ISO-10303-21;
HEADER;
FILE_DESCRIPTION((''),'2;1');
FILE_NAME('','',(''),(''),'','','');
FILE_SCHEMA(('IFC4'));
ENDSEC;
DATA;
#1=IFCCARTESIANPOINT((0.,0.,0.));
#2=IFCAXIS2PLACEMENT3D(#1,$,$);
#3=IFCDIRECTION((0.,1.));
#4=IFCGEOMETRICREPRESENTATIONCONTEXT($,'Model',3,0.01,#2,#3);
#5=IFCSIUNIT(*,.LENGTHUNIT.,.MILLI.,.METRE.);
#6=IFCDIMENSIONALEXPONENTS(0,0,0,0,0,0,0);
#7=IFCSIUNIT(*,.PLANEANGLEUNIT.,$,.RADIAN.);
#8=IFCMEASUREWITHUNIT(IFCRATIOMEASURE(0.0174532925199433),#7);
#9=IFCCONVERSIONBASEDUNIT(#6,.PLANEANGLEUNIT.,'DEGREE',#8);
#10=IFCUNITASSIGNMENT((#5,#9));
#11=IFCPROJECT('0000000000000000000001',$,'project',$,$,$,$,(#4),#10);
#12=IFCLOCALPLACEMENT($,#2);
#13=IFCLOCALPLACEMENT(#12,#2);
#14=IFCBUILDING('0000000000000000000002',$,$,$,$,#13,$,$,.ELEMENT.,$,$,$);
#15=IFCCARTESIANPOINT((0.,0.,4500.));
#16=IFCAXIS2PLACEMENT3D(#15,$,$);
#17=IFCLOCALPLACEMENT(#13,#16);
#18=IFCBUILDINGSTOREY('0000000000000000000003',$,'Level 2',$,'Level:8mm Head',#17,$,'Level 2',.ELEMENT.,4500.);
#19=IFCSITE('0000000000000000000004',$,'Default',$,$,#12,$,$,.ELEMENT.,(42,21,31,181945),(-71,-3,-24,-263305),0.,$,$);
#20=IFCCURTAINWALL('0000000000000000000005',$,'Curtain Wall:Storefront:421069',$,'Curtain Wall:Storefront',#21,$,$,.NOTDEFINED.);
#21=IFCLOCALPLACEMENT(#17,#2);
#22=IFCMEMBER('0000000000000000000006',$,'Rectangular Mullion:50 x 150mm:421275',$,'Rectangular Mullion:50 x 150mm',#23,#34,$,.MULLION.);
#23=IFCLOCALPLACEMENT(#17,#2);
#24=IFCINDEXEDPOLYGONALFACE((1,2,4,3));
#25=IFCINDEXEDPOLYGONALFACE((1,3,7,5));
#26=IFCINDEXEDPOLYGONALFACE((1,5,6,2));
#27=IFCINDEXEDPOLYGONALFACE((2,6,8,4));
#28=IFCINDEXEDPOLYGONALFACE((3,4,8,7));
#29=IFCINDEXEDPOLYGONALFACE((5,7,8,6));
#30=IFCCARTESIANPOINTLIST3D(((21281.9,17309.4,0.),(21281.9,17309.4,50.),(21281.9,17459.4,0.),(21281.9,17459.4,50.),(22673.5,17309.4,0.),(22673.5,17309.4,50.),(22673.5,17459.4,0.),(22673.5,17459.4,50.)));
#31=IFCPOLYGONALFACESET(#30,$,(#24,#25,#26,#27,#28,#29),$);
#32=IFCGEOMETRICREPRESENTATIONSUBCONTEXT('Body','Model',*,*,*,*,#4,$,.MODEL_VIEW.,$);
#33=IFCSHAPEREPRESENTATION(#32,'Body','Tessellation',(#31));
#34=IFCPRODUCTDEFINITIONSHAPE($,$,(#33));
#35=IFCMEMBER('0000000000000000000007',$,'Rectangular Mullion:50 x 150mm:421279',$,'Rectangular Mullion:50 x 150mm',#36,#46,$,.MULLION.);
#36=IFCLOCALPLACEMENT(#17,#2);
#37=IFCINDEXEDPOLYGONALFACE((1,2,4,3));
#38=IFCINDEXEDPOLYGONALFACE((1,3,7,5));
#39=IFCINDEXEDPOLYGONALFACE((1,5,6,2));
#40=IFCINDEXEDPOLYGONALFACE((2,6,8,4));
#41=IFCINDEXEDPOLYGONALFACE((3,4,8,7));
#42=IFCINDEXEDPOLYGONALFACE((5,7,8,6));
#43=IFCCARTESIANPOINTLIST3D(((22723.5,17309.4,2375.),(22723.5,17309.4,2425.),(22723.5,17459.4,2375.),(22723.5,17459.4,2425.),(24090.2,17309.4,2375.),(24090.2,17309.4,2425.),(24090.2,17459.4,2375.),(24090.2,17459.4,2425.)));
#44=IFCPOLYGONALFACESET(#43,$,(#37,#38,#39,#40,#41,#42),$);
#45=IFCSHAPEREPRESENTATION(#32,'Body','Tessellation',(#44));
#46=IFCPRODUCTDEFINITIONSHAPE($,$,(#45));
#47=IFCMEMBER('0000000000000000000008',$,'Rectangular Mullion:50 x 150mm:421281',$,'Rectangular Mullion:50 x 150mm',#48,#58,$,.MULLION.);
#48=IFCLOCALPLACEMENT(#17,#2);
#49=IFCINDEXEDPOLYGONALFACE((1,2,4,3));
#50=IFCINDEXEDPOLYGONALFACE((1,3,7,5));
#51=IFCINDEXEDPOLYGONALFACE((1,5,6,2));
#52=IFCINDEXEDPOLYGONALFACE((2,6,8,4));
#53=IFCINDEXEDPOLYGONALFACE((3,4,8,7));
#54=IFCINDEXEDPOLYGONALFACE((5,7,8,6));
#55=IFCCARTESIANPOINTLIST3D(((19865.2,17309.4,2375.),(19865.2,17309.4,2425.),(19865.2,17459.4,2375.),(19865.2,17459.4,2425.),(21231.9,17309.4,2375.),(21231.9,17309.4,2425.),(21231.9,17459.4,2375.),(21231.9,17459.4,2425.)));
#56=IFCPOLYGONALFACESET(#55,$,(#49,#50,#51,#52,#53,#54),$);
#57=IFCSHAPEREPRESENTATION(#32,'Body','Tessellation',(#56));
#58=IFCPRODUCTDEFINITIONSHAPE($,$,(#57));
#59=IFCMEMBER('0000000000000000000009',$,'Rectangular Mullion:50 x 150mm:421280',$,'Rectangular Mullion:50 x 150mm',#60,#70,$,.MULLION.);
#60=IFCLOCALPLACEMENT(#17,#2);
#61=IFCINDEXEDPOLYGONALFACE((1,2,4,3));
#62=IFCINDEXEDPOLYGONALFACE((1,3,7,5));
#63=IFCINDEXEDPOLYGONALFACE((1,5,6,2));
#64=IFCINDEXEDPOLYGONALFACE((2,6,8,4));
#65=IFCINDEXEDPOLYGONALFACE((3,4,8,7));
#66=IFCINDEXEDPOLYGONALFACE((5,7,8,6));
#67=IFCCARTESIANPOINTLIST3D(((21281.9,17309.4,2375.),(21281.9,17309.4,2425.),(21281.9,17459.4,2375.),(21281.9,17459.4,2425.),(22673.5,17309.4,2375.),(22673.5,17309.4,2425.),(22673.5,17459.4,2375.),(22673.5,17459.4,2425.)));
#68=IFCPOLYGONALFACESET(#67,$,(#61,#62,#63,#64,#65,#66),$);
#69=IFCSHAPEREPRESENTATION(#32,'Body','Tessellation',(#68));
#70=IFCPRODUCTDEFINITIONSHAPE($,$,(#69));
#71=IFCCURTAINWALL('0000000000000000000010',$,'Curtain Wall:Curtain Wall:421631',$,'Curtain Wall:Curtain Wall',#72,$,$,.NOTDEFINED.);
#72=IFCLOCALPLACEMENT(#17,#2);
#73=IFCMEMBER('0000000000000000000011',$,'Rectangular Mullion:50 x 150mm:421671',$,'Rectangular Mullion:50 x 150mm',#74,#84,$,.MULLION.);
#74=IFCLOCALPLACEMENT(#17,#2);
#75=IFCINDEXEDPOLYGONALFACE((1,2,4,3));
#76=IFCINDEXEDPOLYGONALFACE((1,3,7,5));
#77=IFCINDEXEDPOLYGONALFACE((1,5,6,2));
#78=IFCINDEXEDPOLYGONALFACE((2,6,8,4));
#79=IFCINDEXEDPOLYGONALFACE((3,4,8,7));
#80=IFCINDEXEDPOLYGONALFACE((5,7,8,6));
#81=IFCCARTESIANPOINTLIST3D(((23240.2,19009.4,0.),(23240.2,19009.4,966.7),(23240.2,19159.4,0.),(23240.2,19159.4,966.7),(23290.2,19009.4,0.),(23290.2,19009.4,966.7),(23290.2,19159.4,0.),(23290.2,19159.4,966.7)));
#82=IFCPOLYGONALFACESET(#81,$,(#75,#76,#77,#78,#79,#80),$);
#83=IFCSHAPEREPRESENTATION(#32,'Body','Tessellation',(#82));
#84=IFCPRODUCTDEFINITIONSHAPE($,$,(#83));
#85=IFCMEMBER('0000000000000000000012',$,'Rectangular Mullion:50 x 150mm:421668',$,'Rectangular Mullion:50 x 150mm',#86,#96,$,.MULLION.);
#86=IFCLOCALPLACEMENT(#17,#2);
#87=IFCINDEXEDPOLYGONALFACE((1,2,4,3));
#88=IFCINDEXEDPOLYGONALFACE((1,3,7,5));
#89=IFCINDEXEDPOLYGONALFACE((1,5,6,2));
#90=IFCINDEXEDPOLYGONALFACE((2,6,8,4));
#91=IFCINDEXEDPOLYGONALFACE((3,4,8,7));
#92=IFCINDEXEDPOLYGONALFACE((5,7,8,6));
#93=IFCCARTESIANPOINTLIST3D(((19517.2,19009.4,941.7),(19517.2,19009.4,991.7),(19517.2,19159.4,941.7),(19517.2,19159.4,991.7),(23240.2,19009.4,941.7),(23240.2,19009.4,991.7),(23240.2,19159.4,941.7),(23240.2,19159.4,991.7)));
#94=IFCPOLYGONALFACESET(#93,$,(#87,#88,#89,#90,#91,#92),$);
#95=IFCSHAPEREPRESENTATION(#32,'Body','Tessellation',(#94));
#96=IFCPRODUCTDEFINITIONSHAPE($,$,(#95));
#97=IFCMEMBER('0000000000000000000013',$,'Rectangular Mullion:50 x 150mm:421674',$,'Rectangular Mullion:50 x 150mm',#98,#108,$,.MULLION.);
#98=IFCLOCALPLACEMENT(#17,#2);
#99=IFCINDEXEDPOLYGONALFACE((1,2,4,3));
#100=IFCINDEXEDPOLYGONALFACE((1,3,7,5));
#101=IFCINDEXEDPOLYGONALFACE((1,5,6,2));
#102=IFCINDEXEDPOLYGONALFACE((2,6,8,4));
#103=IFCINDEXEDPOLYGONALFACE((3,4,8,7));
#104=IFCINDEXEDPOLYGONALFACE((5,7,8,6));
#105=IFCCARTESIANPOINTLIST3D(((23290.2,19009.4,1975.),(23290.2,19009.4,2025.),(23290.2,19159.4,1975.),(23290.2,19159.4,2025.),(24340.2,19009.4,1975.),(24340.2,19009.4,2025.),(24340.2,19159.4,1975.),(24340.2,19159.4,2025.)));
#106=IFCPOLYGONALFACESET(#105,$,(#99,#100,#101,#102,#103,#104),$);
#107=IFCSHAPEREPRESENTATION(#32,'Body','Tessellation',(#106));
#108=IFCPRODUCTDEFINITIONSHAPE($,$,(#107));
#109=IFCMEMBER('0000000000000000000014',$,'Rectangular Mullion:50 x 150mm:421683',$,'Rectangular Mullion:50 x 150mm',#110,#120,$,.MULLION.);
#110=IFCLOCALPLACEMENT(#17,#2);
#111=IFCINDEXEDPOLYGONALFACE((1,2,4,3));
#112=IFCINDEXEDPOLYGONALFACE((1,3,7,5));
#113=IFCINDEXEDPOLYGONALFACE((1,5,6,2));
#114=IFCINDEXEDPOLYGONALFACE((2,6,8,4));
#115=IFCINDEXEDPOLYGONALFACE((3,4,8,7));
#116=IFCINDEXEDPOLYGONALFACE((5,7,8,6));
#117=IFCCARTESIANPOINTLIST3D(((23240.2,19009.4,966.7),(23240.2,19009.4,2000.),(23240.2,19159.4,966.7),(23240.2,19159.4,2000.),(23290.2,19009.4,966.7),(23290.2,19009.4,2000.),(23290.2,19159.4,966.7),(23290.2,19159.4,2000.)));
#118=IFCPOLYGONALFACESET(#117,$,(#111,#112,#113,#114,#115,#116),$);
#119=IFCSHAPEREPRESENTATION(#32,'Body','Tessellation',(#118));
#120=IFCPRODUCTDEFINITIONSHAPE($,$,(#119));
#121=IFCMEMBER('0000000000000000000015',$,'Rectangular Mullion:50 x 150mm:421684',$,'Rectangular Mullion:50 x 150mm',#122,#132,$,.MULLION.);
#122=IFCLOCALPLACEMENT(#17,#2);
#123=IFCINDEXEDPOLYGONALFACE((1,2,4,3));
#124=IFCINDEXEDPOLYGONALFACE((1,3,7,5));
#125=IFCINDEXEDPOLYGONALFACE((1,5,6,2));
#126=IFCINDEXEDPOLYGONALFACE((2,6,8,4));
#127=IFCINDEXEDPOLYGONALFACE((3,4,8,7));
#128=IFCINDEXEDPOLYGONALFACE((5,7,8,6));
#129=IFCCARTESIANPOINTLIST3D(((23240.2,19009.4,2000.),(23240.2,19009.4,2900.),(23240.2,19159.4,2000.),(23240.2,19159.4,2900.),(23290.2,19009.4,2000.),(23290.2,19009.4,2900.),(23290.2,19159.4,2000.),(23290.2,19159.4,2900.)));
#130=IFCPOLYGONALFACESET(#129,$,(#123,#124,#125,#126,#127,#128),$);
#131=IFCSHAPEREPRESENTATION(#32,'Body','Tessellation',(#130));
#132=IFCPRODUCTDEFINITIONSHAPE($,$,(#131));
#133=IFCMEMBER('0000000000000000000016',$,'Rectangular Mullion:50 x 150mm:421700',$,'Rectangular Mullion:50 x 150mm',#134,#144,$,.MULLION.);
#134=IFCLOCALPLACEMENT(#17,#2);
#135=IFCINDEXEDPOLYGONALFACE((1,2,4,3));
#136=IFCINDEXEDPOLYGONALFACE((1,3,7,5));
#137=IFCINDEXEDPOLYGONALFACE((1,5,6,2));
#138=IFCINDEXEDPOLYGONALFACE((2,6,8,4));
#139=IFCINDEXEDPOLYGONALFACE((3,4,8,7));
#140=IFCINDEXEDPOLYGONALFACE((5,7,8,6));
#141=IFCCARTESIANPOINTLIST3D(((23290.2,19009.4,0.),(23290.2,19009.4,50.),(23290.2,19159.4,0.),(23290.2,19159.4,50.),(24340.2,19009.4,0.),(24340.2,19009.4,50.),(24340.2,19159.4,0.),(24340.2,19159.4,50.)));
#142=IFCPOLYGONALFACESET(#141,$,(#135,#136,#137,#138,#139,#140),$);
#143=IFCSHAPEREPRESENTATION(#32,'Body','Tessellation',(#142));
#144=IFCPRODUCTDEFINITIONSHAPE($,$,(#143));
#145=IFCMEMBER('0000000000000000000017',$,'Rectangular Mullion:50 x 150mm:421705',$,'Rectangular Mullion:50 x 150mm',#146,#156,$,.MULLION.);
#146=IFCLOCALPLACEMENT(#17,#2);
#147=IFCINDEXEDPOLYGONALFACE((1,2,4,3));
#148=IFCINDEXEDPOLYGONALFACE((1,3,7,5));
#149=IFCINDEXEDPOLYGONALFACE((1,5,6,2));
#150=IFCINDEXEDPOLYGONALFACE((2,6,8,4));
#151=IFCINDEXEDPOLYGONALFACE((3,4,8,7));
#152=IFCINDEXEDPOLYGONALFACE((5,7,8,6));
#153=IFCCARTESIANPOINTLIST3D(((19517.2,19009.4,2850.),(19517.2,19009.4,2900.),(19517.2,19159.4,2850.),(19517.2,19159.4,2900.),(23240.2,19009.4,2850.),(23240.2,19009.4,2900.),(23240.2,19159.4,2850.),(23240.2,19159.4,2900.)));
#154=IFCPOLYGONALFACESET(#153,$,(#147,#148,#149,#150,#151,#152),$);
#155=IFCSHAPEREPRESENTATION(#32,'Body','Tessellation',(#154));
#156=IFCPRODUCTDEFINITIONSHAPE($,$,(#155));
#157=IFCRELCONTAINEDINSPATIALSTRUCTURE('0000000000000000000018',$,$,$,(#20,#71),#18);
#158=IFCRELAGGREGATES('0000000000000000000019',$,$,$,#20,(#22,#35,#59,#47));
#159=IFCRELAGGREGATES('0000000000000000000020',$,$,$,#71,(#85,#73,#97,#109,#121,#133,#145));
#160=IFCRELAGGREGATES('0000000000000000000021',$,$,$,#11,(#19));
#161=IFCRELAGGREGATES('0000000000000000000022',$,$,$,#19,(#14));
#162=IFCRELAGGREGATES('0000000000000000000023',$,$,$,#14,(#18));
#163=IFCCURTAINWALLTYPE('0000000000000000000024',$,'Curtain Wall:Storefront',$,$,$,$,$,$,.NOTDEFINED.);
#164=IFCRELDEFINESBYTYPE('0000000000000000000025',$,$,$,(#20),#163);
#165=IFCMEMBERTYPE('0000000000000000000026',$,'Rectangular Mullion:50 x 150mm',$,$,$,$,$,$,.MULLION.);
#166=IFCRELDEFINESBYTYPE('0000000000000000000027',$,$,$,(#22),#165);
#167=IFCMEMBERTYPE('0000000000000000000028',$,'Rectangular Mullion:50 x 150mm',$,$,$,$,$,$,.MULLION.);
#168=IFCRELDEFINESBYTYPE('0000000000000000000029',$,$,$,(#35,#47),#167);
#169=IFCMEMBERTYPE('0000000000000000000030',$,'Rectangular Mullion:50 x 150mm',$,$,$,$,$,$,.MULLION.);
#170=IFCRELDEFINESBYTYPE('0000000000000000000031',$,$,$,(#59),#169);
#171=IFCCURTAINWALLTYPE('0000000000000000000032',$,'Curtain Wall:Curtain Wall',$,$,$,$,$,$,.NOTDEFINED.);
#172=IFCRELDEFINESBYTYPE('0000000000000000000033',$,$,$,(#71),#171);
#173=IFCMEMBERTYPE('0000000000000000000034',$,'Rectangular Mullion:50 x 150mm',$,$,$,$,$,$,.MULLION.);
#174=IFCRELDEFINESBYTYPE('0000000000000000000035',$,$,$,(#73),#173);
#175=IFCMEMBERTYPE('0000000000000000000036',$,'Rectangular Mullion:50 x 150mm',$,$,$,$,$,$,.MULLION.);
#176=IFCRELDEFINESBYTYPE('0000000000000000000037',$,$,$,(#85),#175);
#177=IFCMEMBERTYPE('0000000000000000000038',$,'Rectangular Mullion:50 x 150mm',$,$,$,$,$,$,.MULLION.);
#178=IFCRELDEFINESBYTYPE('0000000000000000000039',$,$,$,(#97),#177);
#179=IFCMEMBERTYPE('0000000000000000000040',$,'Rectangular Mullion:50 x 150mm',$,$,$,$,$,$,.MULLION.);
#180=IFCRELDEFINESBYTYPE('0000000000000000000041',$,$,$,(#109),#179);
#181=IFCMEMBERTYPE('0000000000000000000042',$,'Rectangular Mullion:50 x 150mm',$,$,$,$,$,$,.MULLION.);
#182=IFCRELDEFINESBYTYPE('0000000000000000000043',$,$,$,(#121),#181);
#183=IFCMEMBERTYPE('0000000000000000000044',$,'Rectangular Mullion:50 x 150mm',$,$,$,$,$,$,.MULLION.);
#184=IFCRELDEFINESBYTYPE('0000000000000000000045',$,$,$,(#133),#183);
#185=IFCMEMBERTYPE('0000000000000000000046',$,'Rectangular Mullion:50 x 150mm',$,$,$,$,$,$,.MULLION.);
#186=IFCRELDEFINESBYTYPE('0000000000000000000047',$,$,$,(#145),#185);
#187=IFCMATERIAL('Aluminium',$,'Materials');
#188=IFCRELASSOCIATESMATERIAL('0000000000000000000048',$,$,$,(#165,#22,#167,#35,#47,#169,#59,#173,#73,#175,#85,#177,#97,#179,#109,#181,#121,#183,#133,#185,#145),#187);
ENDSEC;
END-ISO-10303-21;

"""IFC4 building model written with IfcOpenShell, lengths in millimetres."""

from ifc_helpers import new_model, entity, si_unit, converted_unit, direction, frame, origin, place, context, subcontext, project, spatial, indexed_curve, outline, extrude, source, transform, mapped, material, type_object, type_shapes, element, aggregate, save


model = new_model("IFC4")

# Units and contexts
model_context = context("Model", 3, precision=0.01, world=origin(), true_north=direction((0.0, 1.0)))
body_context = subcontext(model_context, "Body", "Model", "MODEL_VIEW")
ifc_project = project(units=[si_unit("LENGTHUNIT", "METRE", prefix="MILLI"), converted_unit("PLANEANGLEUNIT", "DEGREE", entity("IfcRatioMeasure", 0.0174532925199433), si_unit("PLANEANGLEUNIT", "RADIAN"), dimensions=[0, 0, 0, 0, 0, 0, 0])], contexts=[model_context])

# Site, building, storey
site_placement = place(None, origin())
site = spatial("IfcSite", under=ifc_project, at=site_placement, Name="Default", CompositionType="ELEMENT", RefLatitude=(42, 21, 31, 181945), RefLongitude=(-71, -3, -24, -263305), RefElevation=0.0)
building_placement = place(site_placement, origin())
building = spatial("IfcBuilding", under=site, at=building_placement, CompositionType="ELEMENT")
storey_placement = place(building_placement, frame((0.0, 0.0, 4500.0)))
storey = spatial("IfcBuildingStorey", under=building, at=storey_placement, Name="Level 2", ObjectType="Level:8mm Head", LongName="Level 2", CompositionType="ELEMENT", Elevation=4500.0)

# Curtain walls, members
curtain_wall_type_1 = type_object("IfcCurtainWallType", Name="Curtain Wall:Storefront", PredefinedType="NOTDEFINED")
curtain_wall_1_placement = place(storey_placement, frame((0.0, 0.0, -4500.0)))
curtain_wall_1 = element("IfcCurtainWall", 1, at=curtain_wall_1_placement, inside=storey, type_object=curtain_wall_type_1, Name="Curtain Wall:Storefront:421069", ObjectType="Curtain Wall:Storefront", PredefinedType="NOTDEFINED")
ifc_material_1 = material(Name="Aluminium", Category="Materials")
member_type_1 = type_object("IfcMemberType", Name="Rectangular Mullion:50 x 150mm", PredefinedType="MULLION", material=ifc_material_1)
shared_shape_1 = source(origin(), body_context, "Body", "SweptSolid", [
    extrude(outline(indexed_curve([(-75.0, -25.0), (75.0, -25.0), (75.0, 25.0), (-75.0, 25.0), (-75.0, -25.0)], self_intersect=False)), frame((-25.0, 0.0, -1391.7), z_axis=(0.0, 0.0, 1.0), x_axis=(0.0, -1.0, 0.0)), (0.0, 0.0, 1.0), 1391.7),
])
type_shapes(member_type_1, [shared_shape_1])
member_1_placement = place(storey_placement, frame((22673.5, 17384.4, 0.0), z_axis=(1.0, 0.0, 0.0), x_axis=(0.0, 0.0, -1.0)))
member_1 = element("IfcMember", 2, at=member_1_placement, type_object=member_type_1, material=ifc_material_1, Name="Rectangular Mullion:50 x 150mm:421275", ObjectType="Rectangular Mullion:50 x 150mm", PredefinedType="MULLION", context=body_context, shape_type="MappedRepresentation", body=[
    mapped(shared_shape_1, transform((0.0, 0.0, 0.0), scale=1.0)),
])
member_type_2 = type_object("IfcMemberType", Name="Rectangular Mullion:50 x 150mm", PredefinedType="MULLION", material=ifc_material_1)
shared_shape_2 = source(origin(), body_context, "Body", "SweptSolid", [
    extrude(outline(indexed_curve([(-75.0, -25.0), (75.0, -25.0), (75.0, 25.0), (-75.0, 25.0), (-75.0, -25.0)], self_intersect=False)), frame((0.0, 0.0, -1366.7), z_axis=(0.0, 0.0, 1.0), x_axis=(0.0, -1.0, 0.0)), (0.0, 0.0, 1.0), 1366.7),
])
type_shapes(member_type_2, [shared_shape_2])
member_2_placement = place(storey_placement, frame((22723.5, 17384.4, 2400.0), z_axis=(-1.0, 0.0, 0.0), x_axis=(0.0, 0.0, 1.0)))
member_2 = element("IfcMember", 3, at=member_2_placement, type_object=member_type_2, material=ifc_material_1, Name="Rectangular Mullion:50 x 150mm:421279", ObjectType="Rectangular Mullion:50 x 150mm", PredefinedType="MULLION", context=body_context, shape_type="MappedRepresentation", body=[
    mapped(shared_shape_2, transform((0.0, 0.0, 0.0), scale=1.0)),
])
member_3_placement = place(storey_placement, frame((19865.2, 17384.4, 2400.0), z_axis=(-1.0, 0.0, 0.0), x_axis=(0.0, 0.0, 1.0)))
member_3 = element("IfcMember", 4, at=member_3_placement, type_object=member_type_2, material=ifc_material_1, Name="Rectangular Mullion:50 x 150mm:421281", ObjectType="Rectangular Mullion:50 x 150mm", PredefinedType="MULLION", context=body_context, shape_type="MappedRepresentation", body=[
    mapped(shared_shape_2, transform((0.0, 0.0, 0.0), scale=1.0)),
])
member_type_3 = type_object("IfcMemberType", Name="Rectangular Mullion:50 x 150mm", PredefinedType="MULLION", material=ifc_material_1)
shared_shape_3 = source(origin(), body_context, "Body", "SweptSolid", [
    extrude(outline(indexed_curve([(-75.0, -25.0), (75.0, -25.0), (75.0, 25.0), (-75.0, 25.0), (-75.0, -25.0)], self_intersect=False)), frame((0.0, 0.0, -1391.7), z_axis=(0.0, 0.0, 1.0), x_axis=(0.0, -1.0, 0.0)), (0.0, 0.0, 1.0), 1391.7),
])
type_shapes(member_type_3, [shared_shape_3])
member_4_placement = place(storey_placement, frame((21281.9, 17384.4, 2400.0), z_axis=(-1.0, 0.0, 0.0), x_axis=(0.0, 0.0, 1.0)))
member_4 = element("IfcMember", 5, at=member_4_placement, type_object=member_type_3, material=ifc_material_1, Name="Rectangular Mullion:50 x 150mm:421280", ObjectType="Rectangular Mullion:50 x 150mm", PredefinedType="MULLION", context=body_context, shape_type="MappedRepresentation", body=[
    mapped(shared_shape_3, transform((0.0, 0.0, 0.0), scale=1.0)),
])
curtain_wall_type_2 = type_object("IfcCurtainWallType", Name="Curtain Wall:Curtain Wall", PredefinedType="NOTDEFINED")
curtain_wall_2_placement = place(storey_placement, frame((0.0, 0.0, -4500.0)))
curtain_wall_2 = element("IfcCurtainWall", 6, at=curtain_wall_2_placement, inside=storey, type_object=curtain_wall_type_2, Name="Curtain Wall:Curtain Wall:421631", ObjectType="Curtain Wall:Curtain Wall", PredefinedType="NOTDEFINED")
member_type_4 = type_object("IfcMemberType", Name="Rectangular Mullion:50 x 150mm", PredefinedType="MULLION", material=ifc_material_1)
shared_shape_4 = source(origin(), body_context, "Body", "SweptSolid", [
    extrude(outline(indexed_curve([(-75.0, -25.0), (75.0, -25.0), (75.0, 25.0), (-75.0, 25.0), (-75.0, -25.0)], self_intersect=False)), frame((0.0, 0.0, -966.7), z_axis=(0.0, 0.0, 1.0), x_axis=(0.0, -1.0, 0.0)), (0.0, 0.0, 1.0), 966.7),
])
type_shapes(member_type_4, [shared_shape_4])
member_5_placement = place(storey_placement, frame((23265.2, 19084.4, 0.0), z_axis=(0.0, 0.0, -1.0), x_axis=(1.0, 0.0, 0.0)))
member_5 = element("IfcMember", 7, at=member_5_placement, type_object=member_type_4, material=ifc_material_1, Name="Rectangular Mullion:50 x 150mm:421671", ObjectType="Rectangular Mullion:50 x 150mm", PredefinedType="MULLION", context=body_context, shape_type="MappedRepresentation", body=[
    mapped(shared_shape_4, transform((0.0, 0.0, 0.0), scale=1.0)),
])
member_type_5 = type_object("IfcMemberType", Name="Rectangular Mullion:50 x 150mm", PredefinedType="MULLION", material=ifc_material_1)
shared_shape_5 = source(origin(), body_context, "Body", "SweptSolid", [
    extrude(outline(indexed_curve([(-75.0, -25.0), (75.0, -25.0), (75.0, 25.0), (-75.0, 25.0), (-75.0, -25.0)], self_intersect=False)), frame((0.0, 0.0, -3723.0), z_axis=(0.0, 0.0, 1.0), x_axis=(0.0, -1.0, 0.0)), (0.0, 0.0, 1.0), 3723.0),
])
type_shapes(member_type_5, [shared_shape_5])
member_6_placement = place(storey_placement, frame((23240.2, 19084.4, 966.7), z_axis=(1.0, 0.0, 0.0), x_axis=(0.0, 0.0, 1.0)))
member_6 = element("IfcMember", 8, at=member_6_placement, type_object=member_type_5, material=ifc_material_1, Name="Rectangular Mullion:50 x 150mm:421668", ObjectType="Rectangular Mullion:50 x 150mm", PredefinedType="MULLION", context=body_context, shape_type="MappedRepresentation", body=[
    mapped(shared_shape_5, transform((0.0, 0.0, 0.0), scale=1.0)),
])
member_type_6 = type_object("IfcMemberType", Name="Rectangular Mullion:50 x 150mm", PredefinedType="MULLION", material=ifc_material_1)
shared_shape_6 = source(origin(), body_context, "Body", "SweptSolid", [
    extrude(outline(indexed_curve([(-75.0, -25.0), (75.0, -25.0), (75.0, 25.0), (-75.0, 25.0), (-75.0, -25.0)], self_intersect=False)), frame((0.0, 0.0, -1050.0), z_axis=(0.0, 0.0, 1.0), x_axis=(0.0, -1.0, 0.0)), (0.0, 0.0, 1.0), 1050.0),
])
type_shapes(member_type_6, [shared_shape_6])
member_7_placement = place(storey_placement, frame((24340.2, 19084.4, 2000.0), z_axis=(1.0, 0.0, 0.0), x_axis=(0.0, 0.0, 1.0)))
member_7 = element("IfcMember", 9, at=member_7_placement, type_object=member_type_6, material=ifc_material_1, Name="Rectangular Mullion:50 x 150mm:421674", ObjectType="Rectangular Mullion:50 x 150mm", PredefinedType="MULLION", context=body_context, shape_type="MappedRepresentation", body=[
    mapped(shared_shape_6, transform((0.0, 0.0, 0.0), scale=1.0)),
])
member_type_7 = type_object("IfcMemberType", Name="Rectangular Mullion:50 x 150mm", PredefinedType="MULLION", material=ifc_material_1)
shared_shape_7 = source(origin(), body_context, "Body", "SweptSolid", [
    extrude(outline(indexed_curve([(-75.0, -25.0), (75.0, -25.0), (75.0, 25.0), (-75.0, 25.0), (-75.0, -25.0)], self_intersect=False)), frame((0.0, 0.0, -1033.3), z_axis=(0.0, 0.0, 1.0), x_axis=(0.0, -1.0, 0.0)), (0.0, 0.0, 1.0), 1033.3),
])
type_shapes(member_type_7, [shared_shape_7])
member_8_placement = place(storey_placement, frame((23265.2, 19084.4, 966.7), z_axis=(0.0, 0.0, -1.0), x_axis=(1.0, 0.0, 0.0)))
member_8 = element("IfcMember", 10, at=member_8_placement, type_object=member_type_7, material=ifc_material_1, Name="Rectangular Mullion:50 x 150mm:421683", ObjectType="Rectangular Mullion:50 x 150mm", PredefinedType="MULLION", context=body_context, shape_type="MappedRepresentation", body=[
    mapped(shared_shape_7, transform((0.0, 0.0, 0.0), scale=1.0)),
])
member_type_8 = type_object("IfcMemberType", Name="Rectangular Mullion:50 x 150mm", PredefinedType="MULLION", material=ifc_material_1)
shared_shape_8 = source(origin(), body_context, "Body", "SweptSolid", [
    extrude(outline(indexed_curve([(-75.0, -25.0), (75.0, -25.0), (75.0, 25.0), (-75.0, 25.0), (-75.0, -25.0)], self_intersect=False)), frame((0.0, 0.0, -900.0), z_axis=(0.0, 0.0, 1.0), x_axis=(0.0, -1.0, 0.0)), (0.0, 0.0, 1.0), 900.0),
])
type_shapes(member_type_8, [shared_shape_8])
member_9_placement = place(storey_placement, frame((23265.2, 19084.4, 2000.0), z_axis=(0.0, 0.0, -1.0), x_axis=(1.0, 0.0, 0.0)))
member_9 = element("IfcMember", 11, at=member_9_placement, type_object=member_type_8, material=ifc_material_1, Name="Rectangular Mullion:50 x 150mm:421684", ObjectType="Rectangular Mullion:50 x 150mm", PredefinedType="MULLION", context=body_context, shape_type="MappedRepresentation", body=[
    mapped(shared_shape_8, transform((0.0, 0.0, 0.0), scale=1.0)),
])
member_type_9 = type_object("IfcMemberType", Name="Rectangular Mullion:50 x 150mm", PredefinedType="MULLION", material=ifc_material_1)
shared_shape_9 = source(origin(), body_context, "Body", "SweptSolid", [
    extrude(outline(indexed_curve([(-75.0, -25.0), (75.0, -25.0), (75.0, 25.0), (-75.0, 25.0), (-75.0, -25.0)], self_intersect=False)), frame((-25.0, 0.0, -1050.0), z_axis=(0.0, 0.0, 1.0), x_axis=(0.0, -1.0, 0.0)), (0.0, 0.0, 1.0), 1050.0),
])
type_shapes(member_type_9, [shared_shape_9])
member_10_placement = place(storey_placement, frame((23290.2, 19084.4, 0.0), z_axis=(-1.0, 0.0, 0.0), x_axis=(0.0, 0.0, -1.0)))
member_10 = element("IfcMember", 12, at=member_10_placement, type_object=member_type_9, material=ifc_material_1, Name="Rectangular Mullion:50 x 150mm:421700", ObjectType="Rectangular Mullion:50 x 150mm", PredefinedType="MULLION", context=body_context, shape_type="MappedRepresentation", body=[
    mapped(shared_shape_9, transform((0.0, 0.0, 0.0), scale=1.0)),
])
member_type_10 = type_object("IfcMemberType", Name="Rectangular Mullion:50 x 150mm", PredefinedType="MULLION", material=ifc_material_1)
shared_shape_10 = source(origin(), body_context, "Body", "SweptSolid", [
    extrude(outline(indexed_curve([(-75.0, -25.0), (75.0, -25.0), (75.0, 25.0), (-75.0, 25.0), (-75.0, -25.0)], self_intersect=False)), frame((-25.0, 0.0, -3723.0), z_axis=(0.0, 0.0, 1.0), x_axis=(0.0, -1.0, 0.0)), (0.0, 0.0, 1.0), 3723.0),
])
type_shapes(member_type_10, [shared_shape_10])
member_11_placement = place(storey_placement, frame((23240.2, 19084.4, 2900.0), z_axis=(1.0, 0.0, 0.0), x_axis=(0.0, 0.0, 1.0)))
member_11 = element("IfcMember", 13, at=member_11_placement, type_object=member_type_10, material=ifc_material_1, Name="Rectangular Mullion:50 x 150mm:421705", ObjectType="Rectangular Mullion:50 x 150mm", PredefinedType="MULLION", context=body_context, shape_type="MappedRepresentation", body=[
    mapped(shared_shape_10, transform((0.0, 0.0, 0.0), scale=1.0)),
])

aggregate(curtain_wall_1, [member_1, member_2, member_4, member_3])

aggregate(curtain_wall_2, [member_6, member_5, member_7, member_8, member_9, member_10, member_11])

save(model, "model.ifc")
